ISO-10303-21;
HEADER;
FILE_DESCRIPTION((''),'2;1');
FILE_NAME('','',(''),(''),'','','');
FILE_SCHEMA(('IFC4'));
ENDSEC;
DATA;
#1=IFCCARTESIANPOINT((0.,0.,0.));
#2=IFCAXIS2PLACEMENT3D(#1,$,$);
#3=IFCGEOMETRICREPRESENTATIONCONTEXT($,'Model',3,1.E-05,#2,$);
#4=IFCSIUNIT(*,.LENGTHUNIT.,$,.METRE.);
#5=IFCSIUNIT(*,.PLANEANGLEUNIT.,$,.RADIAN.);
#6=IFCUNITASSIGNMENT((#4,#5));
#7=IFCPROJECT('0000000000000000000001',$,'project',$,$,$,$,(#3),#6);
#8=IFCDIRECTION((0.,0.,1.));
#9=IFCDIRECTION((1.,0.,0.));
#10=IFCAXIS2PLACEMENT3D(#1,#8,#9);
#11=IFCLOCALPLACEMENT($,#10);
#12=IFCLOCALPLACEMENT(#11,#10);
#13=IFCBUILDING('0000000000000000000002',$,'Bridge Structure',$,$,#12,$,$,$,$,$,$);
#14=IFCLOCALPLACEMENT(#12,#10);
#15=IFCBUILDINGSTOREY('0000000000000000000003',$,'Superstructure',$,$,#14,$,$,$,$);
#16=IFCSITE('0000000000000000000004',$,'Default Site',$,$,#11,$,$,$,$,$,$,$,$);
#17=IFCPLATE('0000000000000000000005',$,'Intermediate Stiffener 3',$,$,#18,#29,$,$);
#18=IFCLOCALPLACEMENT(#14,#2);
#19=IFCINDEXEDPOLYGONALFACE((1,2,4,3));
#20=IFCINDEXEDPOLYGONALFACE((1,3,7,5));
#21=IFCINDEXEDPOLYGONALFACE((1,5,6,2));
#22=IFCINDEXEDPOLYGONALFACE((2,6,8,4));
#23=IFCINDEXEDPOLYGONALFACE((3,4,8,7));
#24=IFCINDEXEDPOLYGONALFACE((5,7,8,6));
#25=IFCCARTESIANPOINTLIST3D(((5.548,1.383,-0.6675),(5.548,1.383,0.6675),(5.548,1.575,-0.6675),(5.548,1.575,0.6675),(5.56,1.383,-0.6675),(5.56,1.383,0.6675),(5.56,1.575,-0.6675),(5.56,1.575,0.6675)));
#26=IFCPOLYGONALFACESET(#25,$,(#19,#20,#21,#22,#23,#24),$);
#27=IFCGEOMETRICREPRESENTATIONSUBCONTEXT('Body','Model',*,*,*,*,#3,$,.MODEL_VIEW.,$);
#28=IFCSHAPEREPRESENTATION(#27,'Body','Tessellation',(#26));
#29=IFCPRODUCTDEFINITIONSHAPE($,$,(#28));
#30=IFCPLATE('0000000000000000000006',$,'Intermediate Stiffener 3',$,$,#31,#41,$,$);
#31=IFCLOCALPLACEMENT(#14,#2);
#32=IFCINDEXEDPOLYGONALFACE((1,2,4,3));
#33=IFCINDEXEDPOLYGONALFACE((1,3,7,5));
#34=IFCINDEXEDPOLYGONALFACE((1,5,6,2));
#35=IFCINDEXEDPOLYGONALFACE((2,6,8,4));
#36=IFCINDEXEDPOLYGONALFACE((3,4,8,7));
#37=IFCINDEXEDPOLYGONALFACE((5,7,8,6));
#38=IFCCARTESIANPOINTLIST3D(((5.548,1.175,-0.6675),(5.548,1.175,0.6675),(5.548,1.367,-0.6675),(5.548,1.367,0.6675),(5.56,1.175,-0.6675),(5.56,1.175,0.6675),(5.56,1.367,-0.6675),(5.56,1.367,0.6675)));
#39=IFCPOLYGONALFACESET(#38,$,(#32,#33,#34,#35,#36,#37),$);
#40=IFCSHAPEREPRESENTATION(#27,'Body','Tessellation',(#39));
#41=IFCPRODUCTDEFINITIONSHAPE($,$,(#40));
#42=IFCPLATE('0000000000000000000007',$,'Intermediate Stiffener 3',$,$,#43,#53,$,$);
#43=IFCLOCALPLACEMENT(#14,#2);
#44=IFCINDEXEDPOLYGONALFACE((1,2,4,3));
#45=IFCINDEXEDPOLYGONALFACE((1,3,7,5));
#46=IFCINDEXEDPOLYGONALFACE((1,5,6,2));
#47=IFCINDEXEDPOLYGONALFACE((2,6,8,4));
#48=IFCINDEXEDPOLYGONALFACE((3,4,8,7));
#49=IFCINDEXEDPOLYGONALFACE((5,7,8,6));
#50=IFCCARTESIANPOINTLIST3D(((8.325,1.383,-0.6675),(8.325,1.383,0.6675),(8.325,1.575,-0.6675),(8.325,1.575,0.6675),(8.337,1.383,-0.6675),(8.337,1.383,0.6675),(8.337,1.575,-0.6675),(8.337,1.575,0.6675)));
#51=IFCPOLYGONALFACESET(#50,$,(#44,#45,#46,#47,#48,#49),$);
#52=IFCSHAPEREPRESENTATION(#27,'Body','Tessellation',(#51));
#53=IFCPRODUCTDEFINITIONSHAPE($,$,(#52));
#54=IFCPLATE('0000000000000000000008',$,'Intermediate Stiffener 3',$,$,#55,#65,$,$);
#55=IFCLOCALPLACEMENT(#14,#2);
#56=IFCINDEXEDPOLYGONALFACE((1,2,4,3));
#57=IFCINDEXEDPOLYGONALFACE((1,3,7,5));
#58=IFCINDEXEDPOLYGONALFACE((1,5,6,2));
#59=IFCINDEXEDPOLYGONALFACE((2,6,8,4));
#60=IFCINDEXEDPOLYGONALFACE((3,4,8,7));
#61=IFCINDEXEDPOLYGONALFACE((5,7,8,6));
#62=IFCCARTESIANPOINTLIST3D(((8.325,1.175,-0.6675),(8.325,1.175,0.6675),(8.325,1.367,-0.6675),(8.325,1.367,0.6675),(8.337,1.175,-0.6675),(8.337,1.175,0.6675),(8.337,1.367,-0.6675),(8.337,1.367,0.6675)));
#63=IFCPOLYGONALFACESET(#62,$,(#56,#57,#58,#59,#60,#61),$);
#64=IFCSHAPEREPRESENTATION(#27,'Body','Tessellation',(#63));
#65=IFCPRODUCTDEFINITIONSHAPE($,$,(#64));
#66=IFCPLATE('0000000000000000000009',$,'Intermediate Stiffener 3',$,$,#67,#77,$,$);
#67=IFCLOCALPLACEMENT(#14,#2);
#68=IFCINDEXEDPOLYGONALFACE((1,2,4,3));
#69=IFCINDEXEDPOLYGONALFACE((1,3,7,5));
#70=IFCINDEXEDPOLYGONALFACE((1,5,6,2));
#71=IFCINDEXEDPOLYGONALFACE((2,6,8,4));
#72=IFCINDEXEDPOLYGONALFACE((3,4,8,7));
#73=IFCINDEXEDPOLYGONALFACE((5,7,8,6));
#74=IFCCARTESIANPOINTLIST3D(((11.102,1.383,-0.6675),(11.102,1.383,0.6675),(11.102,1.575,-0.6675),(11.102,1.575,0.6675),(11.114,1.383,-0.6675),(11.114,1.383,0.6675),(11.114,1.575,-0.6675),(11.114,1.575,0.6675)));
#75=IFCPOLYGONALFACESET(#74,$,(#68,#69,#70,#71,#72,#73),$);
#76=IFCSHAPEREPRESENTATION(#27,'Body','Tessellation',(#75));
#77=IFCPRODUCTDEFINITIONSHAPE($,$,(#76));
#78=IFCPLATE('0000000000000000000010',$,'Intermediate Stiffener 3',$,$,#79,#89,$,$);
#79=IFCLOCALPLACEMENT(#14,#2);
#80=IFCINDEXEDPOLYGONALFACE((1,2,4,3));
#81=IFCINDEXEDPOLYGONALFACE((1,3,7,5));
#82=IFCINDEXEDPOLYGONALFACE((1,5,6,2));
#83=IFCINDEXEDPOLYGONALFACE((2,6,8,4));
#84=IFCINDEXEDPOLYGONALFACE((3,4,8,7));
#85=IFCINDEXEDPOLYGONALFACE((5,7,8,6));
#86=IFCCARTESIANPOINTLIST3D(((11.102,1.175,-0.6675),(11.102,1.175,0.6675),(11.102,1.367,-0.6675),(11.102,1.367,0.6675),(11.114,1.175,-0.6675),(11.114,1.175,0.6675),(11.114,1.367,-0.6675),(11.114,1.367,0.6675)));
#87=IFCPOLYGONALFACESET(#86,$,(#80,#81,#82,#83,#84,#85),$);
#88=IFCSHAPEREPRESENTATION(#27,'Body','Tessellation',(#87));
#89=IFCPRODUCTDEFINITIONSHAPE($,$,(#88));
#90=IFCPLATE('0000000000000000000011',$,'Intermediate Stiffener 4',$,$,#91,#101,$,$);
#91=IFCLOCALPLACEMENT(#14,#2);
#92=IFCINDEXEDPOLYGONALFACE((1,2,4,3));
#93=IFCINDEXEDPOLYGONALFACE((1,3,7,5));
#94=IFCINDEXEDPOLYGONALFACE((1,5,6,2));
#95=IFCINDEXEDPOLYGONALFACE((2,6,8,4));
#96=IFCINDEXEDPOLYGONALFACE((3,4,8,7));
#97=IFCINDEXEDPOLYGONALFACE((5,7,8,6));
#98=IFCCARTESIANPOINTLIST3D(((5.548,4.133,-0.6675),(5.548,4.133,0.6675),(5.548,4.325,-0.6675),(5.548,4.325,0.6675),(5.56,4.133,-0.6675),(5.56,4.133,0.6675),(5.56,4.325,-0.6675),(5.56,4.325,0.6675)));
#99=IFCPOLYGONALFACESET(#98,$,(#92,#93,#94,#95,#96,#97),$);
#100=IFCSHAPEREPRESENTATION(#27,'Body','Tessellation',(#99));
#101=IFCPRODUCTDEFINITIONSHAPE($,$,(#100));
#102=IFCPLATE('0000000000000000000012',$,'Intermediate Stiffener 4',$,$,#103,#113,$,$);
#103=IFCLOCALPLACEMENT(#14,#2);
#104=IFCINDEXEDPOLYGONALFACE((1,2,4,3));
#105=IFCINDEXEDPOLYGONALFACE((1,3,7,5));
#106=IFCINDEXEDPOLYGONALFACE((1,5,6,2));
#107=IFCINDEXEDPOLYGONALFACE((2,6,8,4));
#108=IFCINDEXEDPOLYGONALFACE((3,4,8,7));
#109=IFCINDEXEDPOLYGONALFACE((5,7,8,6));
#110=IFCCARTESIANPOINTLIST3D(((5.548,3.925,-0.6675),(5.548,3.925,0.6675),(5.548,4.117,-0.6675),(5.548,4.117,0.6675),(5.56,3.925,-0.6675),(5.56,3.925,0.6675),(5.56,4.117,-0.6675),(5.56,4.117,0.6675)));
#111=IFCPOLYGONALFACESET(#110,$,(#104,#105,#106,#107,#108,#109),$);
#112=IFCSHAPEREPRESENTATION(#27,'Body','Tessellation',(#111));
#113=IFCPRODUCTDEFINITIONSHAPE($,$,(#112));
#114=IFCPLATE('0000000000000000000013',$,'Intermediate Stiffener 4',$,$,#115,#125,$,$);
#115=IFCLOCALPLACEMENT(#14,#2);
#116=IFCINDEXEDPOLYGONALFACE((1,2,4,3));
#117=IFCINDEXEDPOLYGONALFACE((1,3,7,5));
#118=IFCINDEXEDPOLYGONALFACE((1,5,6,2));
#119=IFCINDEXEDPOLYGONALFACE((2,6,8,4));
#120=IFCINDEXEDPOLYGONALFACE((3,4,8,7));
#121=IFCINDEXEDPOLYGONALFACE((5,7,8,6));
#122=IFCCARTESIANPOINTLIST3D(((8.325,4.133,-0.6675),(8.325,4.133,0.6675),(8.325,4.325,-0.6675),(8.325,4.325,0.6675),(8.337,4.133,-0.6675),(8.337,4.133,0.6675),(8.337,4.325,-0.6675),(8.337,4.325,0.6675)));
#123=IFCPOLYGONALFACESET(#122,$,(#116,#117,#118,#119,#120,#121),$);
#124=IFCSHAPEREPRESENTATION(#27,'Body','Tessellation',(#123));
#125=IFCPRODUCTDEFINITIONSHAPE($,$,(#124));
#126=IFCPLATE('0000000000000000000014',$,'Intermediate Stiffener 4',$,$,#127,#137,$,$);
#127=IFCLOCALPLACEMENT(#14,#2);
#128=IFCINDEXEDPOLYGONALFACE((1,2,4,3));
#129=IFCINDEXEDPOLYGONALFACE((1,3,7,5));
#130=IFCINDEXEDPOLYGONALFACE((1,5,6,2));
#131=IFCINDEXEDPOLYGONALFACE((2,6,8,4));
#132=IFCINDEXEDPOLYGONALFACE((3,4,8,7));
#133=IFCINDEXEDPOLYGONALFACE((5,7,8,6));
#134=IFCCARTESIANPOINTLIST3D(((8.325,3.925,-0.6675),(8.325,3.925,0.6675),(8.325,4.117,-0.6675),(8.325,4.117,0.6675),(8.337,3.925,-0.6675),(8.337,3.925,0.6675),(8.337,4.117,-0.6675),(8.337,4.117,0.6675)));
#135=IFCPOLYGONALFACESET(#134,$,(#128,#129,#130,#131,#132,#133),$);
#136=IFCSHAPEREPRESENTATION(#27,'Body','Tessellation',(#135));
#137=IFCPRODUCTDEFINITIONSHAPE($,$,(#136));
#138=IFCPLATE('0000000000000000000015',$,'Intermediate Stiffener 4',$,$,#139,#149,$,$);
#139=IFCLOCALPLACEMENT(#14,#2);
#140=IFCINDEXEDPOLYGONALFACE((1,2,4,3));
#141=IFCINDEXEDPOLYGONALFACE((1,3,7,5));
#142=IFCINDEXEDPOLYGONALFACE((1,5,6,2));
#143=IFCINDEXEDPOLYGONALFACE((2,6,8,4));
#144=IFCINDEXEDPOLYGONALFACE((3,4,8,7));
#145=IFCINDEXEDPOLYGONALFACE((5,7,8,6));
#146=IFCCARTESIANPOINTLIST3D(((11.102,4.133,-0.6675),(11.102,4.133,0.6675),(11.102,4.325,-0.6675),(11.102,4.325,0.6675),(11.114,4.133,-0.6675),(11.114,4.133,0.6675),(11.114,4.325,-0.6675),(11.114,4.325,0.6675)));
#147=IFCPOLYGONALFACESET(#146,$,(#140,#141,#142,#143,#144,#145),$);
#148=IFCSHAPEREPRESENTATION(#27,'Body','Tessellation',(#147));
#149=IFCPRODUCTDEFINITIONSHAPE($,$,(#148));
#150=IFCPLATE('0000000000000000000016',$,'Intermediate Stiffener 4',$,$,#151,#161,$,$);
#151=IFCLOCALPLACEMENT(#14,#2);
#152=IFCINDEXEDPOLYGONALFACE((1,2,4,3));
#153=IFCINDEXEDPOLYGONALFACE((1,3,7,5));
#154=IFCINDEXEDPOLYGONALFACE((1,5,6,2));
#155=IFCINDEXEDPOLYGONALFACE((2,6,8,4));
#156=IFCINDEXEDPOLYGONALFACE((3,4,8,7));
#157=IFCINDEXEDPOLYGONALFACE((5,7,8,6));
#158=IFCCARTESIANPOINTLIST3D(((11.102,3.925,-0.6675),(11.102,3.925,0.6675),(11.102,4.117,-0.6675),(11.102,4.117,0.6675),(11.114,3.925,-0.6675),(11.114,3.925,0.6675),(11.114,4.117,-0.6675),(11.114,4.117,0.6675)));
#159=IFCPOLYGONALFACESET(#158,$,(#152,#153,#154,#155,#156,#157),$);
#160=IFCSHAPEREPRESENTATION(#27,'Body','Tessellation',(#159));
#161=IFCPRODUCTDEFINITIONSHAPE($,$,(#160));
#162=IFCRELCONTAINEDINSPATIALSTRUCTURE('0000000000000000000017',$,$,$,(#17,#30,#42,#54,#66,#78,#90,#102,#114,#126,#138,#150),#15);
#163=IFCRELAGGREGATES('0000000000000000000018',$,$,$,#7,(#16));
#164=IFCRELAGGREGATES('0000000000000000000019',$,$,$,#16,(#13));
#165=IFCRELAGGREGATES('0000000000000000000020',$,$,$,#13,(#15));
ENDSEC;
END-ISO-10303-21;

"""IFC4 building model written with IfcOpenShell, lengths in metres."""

from ifc_helpers import new_model, si_unit, frame, origin, origin_with_axes, origin_2d_with_axis, place, context, subcontext, project, spatial, rectangle, extrude, element, save


model = new_model("IFC4")

# Units and contexts
model_context = context("Model", 3, precision=1e-05, world=origin())
body_context = subcontext(model_context, "Body", "Model", "MODEL_VIEW")
ifc_project = project(units=[si_unit("LENGTHUNIT", "METRE"), si_unit("PLANEANGLEUNIT", "RADIAN")], contexts=[model_context])

# Site, building, storey
site_placement = place(None, origin_with_axes())
site = spatial("IfcSite", under=ifc_project, at=site_placement, Name="Default Site")
building_placement = place(site_placement, origin_with_axes())
building = spatial("IfcBuilding", under=site, at=building_placement, Name="Bridge Structure")
storey_placement = place(building_placement, origin_with_axes())
storey = spatial("IfcBuildingStorey", under=building, at=storey_placement, Name="Superstructure")

# Plates
for number, where, z_axis, x_axis, name in (
    (1, (5.554, 1.479, -0.6675), (0.0, 0.0, 1.0), (1.0, 0.0, 0.0), "Intermediate Stiffener 3"),
    (2, (5.554, 1.271, -0.6675), (0.0, 0.0, 1.0), (1.0, 0.0, 0.0), "Intermediate Stiffener 3"),
    (3, (8.331, 1.479, -0.6675), (0.0, 0.0, 1.0), (1.0, 0.0, 0.0), "Intermediate Stiffener 3"),
    (4, (8.331, 1.271, -0.6675), (0.0, 0.0, 1.0), (1.0, 0.0, 0.0), "Intermediate Stiffener 3"),
    (5, (11.108, 1.479, -0.6675), (0.0, 0.0, 1.0), (1.0, 0.0, 0.0), "Intermediate Stiffener 3"),
    (6, (11.108, 1.271, -0.6675), (0.0, 0.0, 1.0), (1.0, 0.0, 0.0), "Intermediate Stiffener 3"),
    (7, (5.554, 4.229, -0.6675), (0.0, 0.0, 1.0), (1.0, 0.0, 0.0), "Intermediate Stiffener 4"),
    (8, (5.554, 4.021, -0.6675), (0.0, 0.0, 1.0), (1.0, 0.0, 0.0), "Intermediate Stiffener 4"),
    (9, (8.331, 4.229, -0.6675), (0.0, 0.0, 1.0), (1.0, 0.0, 0.0), "Intermediate Stiffener 4"),
    (10, (8.331, 4.021, -0.6675), (0.0, 0.0, 1.0), (1.0, 0.0, 0.0), "Intermediate Stiffener 4"),
    (11, (11.108, 4.229, -0.6675), (0.0, 0.0, 1.0), (1.0, 0.0, 0.0), "Intermediate Stiffener 4"),
    (12, (11.108, 4.021, -0.6675), (0.0, 0.0, 1.0), (1.0, 0.0, 0.0), "Intermediate Stiffener 4"),
):
    element("IfcPlate", number, at=place(storey_placement, frame(where, z_axis=z_axis, x_axis=x_axis)), inside=storey, Name=name, context=body_context, shape_type="SweptSolid", body=[
        extrude(rectangle(XDim=0.012, YDim=0.192, at=origin_2d_with_axis()), origin_with_axes(), (0.0, 0.0, 1.0), 1.335),
    ])

save(model, "model.ifc")
